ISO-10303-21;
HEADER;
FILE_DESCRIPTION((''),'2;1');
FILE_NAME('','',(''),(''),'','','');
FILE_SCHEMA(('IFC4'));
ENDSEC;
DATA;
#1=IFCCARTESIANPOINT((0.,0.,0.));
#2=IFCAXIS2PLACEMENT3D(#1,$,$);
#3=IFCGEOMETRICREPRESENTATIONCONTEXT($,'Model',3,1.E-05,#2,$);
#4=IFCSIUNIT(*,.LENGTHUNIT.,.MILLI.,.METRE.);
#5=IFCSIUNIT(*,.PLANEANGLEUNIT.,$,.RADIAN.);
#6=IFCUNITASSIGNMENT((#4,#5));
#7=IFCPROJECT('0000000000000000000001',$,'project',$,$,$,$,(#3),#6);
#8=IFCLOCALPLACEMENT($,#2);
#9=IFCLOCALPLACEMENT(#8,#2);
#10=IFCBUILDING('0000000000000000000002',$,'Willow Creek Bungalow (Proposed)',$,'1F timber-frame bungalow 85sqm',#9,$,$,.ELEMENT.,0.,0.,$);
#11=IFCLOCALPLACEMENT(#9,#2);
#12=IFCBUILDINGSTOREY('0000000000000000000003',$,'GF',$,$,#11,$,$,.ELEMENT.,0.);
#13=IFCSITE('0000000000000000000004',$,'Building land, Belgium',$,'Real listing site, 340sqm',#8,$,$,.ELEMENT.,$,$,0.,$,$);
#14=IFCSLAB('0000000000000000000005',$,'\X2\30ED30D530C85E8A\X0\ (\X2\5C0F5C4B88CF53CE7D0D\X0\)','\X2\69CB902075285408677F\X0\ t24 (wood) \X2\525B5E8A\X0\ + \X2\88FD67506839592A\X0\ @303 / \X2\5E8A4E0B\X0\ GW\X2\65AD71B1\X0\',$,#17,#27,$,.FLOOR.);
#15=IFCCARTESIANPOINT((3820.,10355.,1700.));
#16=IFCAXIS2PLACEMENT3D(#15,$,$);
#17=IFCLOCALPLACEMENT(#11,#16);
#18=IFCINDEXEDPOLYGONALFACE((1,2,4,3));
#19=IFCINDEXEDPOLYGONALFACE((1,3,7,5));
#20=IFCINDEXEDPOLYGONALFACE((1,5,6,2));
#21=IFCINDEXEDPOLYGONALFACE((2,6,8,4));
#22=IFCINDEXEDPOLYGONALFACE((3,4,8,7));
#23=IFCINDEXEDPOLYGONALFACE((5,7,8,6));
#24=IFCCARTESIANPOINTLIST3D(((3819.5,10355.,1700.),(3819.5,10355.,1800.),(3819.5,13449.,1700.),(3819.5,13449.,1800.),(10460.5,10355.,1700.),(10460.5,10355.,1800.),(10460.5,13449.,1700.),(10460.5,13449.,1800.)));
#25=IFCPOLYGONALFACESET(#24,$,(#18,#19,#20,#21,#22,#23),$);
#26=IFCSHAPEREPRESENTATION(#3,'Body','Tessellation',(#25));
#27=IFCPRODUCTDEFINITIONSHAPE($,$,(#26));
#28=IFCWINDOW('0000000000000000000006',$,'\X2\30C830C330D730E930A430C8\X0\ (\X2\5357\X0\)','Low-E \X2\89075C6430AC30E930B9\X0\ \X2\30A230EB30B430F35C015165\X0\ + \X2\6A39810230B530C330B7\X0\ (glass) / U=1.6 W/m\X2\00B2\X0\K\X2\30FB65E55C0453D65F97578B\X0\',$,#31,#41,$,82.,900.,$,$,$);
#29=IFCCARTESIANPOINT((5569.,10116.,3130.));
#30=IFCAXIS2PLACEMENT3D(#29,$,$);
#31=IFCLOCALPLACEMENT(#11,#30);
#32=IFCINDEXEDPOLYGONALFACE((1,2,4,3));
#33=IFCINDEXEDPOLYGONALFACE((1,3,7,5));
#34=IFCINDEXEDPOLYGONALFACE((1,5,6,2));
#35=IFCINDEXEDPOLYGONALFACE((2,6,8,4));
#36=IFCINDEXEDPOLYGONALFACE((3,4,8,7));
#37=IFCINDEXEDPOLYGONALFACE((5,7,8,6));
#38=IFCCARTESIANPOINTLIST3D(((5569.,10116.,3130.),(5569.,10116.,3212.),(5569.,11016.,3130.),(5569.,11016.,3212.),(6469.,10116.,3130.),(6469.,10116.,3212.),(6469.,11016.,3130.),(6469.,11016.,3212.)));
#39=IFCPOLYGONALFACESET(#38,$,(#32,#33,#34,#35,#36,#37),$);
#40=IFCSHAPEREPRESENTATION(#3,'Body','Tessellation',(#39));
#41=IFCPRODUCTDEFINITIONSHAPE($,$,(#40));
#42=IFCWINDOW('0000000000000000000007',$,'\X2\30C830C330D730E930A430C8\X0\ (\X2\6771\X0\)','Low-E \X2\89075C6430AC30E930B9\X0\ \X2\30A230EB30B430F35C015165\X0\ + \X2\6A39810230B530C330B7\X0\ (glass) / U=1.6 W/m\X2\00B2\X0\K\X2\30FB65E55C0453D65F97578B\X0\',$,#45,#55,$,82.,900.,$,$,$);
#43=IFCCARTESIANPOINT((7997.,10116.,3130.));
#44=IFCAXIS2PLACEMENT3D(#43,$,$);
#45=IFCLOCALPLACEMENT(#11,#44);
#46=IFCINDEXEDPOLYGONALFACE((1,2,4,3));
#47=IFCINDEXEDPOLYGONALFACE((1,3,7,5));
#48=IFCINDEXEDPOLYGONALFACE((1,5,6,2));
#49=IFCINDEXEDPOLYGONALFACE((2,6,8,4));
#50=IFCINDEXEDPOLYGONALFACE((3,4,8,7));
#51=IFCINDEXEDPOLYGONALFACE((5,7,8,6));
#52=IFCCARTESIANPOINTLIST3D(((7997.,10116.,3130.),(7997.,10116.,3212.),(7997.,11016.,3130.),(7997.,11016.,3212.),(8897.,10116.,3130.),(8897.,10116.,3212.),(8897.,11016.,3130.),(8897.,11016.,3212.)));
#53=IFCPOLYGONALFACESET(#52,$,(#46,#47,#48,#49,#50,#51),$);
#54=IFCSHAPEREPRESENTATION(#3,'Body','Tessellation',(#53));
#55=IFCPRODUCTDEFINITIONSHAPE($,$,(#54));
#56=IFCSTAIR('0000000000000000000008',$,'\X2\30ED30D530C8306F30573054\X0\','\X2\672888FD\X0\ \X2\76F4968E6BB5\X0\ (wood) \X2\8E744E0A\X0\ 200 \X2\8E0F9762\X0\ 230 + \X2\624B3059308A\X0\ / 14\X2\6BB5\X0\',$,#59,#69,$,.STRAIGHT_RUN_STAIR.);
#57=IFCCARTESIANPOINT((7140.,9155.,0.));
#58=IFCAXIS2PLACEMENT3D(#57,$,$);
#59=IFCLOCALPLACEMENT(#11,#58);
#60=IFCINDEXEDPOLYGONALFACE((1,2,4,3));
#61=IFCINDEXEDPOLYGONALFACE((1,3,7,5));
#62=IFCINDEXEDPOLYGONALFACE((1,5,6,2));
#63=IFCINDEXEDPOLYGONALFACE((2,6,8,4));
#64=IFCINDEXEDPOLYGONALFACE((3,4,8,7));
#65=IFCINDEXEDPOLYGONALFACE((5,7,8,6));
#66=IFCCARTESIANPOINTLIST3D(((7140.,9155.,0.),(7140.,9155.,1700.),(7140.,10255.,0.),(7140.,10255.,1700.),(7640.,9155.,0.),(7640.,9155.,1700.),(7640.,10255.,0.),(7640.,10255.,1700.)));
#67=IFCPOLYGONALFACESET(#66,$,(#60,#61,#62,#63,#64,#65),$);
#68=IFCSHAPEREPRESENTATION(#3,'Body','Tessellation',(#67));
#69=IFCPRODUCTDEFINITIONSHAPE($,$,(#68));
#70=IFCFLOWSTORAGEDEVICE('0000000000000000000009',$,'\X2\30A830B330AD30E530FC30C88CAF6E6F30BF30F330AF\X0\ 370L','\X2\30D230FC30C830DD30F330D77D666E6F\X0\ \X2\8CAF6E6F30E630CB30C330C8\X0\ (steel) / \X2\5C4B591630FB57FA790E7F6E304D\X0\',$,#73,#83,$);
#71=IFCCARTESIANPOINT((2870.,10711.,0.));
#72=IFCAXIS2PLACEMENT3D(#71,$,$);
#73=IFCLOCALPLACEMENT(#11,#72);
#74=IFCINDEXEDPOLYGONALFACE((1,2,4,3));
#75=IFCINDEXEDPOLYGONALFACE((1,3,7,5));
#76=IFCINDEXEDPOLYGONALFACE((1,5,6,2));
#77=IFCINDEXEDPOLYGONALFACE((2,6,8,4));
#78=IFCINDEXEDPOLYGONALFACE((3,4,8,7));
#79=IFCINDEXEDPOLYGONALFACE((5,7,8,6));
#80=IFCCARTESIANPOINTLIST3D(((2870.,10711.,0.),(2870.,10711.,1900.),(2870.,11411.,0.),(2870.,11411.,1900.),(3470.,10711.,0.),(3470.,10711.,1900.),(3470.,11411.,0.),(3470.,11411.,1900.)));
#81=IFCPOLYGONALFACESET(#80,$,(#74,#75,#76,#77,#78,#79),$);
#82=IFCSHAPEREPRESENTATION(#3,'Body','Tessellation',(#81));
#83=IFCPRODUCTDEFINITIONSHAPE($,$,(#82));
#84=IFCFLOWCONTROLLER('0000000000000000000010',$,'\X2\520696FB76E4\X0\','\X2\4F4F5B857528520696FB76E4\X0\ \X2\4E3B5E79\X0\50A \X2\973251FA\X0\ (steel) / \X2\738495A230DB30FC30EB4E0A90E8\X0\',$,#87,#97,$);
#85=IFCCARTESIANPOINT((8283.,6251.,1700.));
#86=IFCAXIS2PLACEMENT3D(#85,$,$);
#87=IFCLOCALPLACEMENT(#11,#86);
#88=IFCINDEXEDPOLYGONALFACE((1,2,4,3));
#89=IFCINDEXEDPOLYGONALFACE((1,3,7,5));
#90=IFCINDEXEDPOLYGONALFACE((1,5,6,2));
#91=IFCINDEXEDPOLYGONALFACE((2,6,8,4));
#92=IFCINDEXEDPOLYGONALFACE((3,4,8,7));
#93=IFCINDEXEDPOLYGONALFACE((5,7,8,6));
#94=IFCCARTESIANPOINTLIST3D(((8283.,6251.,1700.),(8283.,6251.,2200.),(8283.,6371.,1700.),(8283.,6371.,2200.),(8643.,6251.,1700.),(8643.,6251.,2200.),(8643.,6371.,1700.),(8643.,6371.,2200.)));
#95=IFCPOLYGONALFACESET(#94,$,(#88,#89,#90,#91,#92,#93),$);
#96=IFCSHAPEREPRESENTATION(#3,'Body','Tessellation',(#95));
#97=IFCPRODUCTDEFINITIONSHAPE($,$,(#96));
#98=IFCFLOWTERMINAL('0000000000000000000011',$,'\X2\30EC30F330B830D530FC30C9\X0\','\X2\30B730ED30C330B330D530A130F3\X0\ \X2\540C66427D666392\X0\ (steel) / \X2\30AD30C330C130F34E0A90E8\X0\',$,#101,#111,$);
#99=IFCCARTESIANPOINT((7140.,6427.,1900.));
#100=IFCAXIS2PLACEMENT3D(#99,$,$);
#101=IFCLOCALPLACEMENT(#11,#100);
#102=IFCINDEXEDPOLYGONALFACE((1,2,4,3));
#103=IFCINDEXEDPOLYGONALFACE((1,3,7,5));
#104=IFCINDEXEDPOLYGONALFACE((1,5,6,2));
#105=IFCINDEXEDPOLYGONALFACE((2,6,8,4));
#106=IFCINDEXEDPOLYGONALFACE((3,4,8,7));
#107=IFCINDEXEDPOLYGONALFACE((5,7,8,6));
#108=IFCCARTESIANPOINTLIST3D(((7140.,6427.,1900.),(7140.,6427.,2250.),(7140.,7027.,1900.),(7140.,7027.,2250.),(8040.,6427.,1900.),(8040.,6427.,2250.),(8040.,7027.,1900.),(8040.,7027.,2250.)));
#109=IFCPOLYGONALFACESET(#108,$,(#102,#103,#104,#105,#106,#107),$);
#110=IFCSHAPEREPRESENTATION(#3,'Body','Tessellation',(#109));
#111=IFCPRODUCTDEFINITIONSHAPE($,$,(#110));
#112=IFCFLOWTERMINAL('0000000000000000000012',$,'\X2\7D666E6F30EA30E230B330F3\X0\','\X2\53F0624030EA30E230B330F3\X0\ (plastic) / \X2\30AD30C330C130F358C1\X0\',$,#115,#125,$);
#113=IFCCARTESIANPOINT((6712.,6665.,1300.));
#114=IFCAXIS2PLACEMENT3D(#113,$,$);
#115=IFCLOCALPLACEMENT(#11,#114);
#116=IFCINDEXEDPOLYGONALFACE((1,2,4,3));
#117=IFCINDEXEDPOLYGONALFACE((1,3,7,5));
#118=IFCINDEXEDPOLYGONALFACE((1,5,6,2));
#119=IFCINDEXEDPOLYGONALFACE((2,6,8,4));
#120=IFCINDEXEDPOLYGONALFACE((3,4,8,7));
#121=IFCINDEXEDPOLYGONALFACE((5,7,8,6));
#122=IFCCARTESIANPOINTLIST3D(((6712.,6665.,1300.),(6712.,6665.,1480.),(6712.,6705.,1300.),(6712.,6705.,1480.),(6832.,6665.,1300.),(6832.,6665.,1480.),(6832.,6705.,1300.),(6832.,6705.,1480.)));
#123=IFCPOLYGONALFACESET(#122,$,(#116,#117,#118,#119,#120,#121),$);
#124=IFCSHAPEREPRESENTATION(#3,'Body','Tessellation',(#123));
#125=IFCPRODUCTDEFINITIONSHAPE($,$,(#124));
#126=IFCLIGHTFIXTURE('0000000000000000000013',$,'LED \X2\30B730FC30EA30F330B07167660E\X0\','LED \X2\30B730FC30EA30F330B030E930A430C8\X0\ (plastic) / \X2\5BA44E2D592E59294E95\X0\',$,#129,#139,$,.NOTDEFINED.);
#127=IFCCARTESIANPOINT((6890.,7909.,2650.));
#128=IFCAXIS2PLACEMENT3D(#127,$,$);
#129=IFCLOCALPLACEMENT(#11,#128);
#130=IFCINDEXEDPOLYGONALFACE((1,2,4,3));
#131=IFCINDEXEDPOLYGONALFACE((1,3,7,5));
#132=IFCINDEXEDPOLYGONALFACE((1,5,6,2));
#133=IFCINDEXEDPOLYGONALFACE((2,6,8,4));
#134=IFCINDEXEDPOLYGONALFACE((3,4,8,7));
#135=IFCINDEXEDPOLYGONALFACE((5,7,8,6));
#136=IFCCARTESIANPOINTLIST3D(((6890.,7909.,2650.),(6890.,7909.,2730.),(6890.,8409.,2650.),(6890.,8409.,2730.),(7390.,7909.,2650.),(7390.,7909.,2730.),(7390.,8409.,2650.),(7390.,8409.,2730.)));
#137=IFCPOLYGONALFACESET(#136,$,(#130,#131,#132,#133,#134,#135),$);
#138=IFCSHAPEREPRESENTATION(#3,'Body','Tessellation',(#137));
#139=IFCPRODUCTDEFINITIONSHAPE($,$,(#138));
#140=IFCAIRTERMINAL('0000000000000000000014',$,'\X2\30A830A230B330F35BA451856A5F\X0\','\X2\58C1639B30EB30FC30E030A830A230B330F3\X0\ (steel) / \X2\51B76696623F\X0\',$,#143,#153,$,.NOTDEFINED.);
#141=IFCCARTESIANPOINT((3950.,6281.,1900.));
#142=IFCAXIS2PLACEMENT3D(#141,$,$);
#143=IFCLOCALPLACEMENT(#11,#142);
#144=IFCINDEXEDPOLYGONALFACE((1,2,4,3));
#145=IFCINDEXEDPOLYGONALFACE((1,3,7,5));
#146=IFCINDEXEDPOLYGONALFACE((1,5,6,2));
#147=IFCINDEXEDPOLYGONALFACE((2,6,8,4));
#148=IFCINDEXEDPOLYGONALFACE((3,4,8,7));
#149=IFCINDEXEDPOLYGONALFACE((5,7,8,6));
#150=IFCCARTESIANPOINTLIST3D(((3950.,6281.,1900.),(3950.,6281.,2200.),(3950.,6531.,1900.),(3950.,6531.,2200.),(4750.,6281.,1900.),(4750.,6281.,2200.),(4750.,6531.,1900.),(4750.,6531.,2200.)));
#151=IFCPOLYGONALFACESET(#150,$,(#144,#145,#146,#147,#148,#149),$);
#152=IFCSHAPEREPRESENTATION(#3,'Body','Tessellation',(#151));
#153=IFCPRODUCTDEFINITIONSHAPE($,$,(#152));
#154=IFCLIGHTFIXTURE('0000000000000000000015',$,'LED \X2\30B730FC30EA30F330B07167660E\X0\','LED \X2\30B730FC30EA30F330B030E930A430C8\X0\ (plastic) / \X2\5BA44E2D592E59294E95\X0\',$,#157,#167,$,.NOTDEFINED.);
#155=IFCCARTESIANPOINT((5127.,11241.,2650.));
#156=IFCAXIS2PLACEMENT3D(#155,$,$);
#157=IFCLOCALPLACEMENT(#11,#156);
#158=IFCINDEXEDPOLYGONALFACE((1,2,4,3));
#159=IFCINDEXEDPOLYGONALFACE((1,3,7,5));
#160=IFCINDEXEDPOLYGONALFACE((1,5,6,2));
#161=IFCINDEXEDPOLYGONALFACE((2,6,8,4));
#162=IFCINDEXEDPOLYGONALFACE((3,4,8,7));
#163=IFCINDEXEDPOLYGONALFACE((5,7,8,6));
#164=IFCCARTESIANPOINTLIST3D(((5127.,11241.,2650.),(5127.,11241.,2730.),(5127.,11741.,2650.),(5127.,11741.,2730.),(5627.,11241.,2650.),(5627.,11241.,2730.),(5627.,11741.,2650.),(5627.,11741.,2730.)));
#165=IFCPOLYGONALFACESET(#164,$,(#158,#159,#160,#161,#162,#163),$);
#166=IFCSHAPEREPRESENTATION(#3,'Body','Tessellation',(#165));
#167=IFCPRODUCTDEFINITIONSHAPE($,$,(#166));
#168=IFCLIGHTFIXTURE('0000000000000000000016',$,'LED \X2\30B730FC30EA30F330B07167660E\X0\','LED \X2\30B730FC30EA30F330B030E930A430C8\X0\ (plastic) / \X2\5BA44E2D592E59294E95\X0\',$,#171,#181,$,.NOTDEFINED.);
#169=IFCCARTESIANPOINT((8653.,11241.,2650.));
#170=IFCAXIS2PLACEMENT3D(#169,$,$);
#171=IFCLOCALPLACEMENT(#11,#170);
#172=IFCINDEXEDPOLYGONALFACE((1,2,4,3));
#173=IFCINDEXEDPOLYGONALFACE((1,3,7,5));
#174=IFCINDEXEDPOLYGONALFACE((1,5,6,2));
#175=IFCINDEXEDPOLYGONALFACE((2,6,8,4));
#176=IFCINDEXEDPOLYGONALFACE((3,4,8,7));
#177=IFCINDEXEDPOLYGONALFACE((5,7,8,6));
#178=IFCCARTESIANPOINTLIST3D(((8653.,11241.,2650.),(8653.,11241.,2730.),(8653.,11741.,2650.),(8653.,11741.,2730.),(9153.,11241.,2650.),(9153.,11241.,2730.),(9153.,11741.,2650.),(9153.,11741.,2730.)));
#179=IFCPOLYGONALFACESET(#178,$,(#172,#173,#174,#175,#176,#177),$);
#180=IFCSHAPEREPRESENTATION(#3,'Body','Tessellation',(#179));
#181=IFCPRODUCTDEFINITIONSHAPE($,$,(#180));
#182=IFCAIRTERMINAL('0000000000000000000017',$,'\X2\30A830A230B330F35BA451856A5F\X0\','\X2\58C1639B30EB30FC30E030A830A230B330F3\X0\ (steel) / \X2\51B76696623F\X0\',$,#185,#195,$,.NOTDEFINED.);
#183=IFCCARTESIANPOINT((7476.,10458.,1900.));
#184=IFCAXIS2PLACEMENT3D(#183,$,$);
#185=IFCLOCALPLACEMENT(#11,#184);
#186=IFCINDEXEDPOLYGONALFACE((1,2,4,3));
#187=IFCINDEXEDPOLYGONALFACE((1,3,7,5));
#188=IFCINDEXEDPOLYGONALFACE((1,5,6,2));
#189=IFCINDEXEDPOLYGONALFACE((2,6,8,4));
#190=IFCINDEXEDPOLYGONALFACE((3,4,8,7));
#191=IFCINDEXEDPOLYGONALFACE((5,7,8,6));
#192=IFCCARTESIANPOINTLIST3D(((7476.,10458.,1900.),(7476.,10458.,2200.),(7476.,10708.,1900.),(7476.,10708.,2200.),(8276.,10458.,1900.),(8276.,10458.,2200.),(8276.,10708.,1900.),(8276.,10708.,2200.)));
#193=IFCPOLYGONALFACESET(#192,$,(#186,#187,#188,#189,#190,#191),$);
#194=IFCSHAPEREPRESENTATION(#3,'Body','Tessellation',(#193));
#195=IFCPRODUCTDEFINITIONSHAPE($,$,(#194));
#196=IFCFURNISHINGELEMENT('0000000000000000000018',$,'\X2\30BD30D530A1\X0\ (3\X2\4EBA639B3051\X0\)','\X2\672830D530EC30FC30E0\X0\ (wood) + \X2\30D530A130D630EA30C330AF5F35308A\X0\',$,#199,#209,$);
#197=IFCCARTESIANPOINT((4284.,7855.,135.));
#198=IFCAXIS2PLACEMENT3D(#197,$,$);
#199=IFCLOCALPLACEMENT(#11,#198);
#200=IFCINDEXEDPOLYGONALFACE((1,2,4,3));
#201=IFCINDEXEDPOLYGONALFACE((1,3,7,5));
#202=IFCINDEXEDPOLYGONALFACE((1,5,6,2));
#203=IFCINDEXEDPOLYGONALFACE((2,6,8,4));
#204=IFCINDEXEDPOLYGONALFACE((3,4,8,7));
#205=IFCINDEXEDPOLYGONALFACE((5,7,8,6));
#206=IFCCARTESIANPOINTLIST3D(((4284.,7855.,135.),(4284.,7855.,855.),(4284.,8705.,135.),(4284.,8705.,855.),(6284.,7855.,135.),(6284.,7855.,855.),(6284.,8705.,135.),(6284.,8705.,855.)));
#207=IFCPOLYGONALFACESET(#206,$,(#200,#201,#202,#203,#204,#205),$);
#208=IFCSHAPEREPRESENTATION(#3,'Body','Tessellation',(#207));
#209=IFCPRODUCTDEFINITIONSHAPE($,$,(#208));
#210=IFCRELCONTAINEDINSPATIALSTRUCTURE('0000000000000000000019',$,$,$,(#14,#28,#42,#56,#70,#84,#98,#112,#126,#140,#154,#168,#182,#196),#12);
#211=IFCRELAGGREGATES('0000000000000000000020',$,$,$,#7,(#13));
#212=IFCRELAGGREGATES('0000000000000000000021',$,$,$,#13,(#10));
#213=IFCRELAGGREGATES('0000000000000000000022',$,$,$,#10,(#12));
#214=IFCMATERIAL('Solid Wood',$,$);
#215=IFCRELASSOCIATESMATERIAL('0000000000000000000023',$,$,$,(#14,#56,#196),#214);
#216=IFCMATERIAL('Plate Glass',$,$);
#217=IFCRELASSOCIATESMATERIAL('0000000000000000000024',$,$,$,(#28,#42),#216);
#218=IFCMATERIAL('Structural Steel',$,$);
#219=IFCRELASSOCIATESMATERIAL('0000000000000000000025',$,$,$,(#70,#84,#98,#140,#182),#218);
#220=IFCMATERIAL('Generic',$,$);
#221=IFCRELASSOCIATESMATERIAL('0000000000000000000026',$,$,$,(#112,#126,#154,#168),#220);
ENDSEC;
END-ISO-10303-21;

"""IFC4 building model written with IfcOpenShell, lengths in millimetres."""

from ifc_helpers import new_model, si_unit, frame, frame_2d, origin, place, context, project, spatial, rectangle, extrude, material, element, save


model = new_model("IFC4")

# Units and contexts
model_context = context("Model", 3, precision=1e-05, world=origin())
ifc_project = project(units=[si_unit("LENGTHUNIT", "METRE", prefix="MILLI"), si_unit("PLANEANGLEUNIT", "RADIAN")], contexts=[model_context])

# Site, building, storey
site_placement = place(None, origin())
site = spatial("IfcSite", under=ifc_project, at=site_placement, Name="Building land, Belgium", ObjectType="Real listing site, 340sqm", CompositionType="ELEMENT", RefElevation=0.0)
building_placement = place(site_placement, origin())
building = spatial("IfcBuilding", under=site, at=building_placement, Name="Willow Creek Bungalow (Proposed)", ObjectType="1F timber-frame bungalow 85sqm", CompositionType="ELEMENT", ElevationOfRefHeight=0.0, ElevationOfTerrain=0.0)
storey_placement = place(building_placement, origin())
storey = spatial("IfcBuildingStorey", under=building, at=storey_placement, Name="GF", CompositionType="ELEMENT", Elevation=0.0)

# Shared definitions
ifc_material_1 = material(Name="Solid Wood")

# Slab
slab_placement = place(storey_placement, frame((3820.0, 10355.0, 1700.0)))
element("IfcSlab", 1, at=slab_placement, inside=storey, material=ifc_material_1, Name="ロフト床 (小屋裏収納)", Description="構造用合板 t24 (wood) 剛床 + 製材根太 @303 / 床下 GW断熱", PredefinedType="FLOOR", context=model_context, shape_type="SweptSolid", body=[
    extrude(rectangle(XDim=6641.0, YDim=3094.0, at=frame_2d((3320.0, 1547.0))), frame((3820.0, 10355.0, 1700.0)), (0.0, 0.0, 1.0), 100.0),
])

# Windows
ifc_material_2 = material(Name="Plate Glass")
window_1_placement = place(storey_placement, frame((5569.0, 10116.0, 3130.0)))
element("IfcWindow", 2, at=window_1_placement, inside=storey, material=ifc_material_2, Name="トップライト (南)", Description="Low-E 複層ガラス アルゴン封入 + 樹脂サッシ (glass) / U=1.6 W/m²K・日射取得型", OverallHeight=82.0, OverallWidth=900.0, context=model_context, shape_type="SweptSolid", body=[
    extrude(rectangle(XDim=900.0, YDim=900.0, at=frame_2d((450.0, 450.0))), frame((5569.0, 10116.0, 3130.0)), (0.0, 0.0, 1.0), 82.0),
])
window_2_placement = place(storey_placement, frame((7997.0, 10116.0, 3130.0)))
element("IfcWindow", 3, at=window_2_placement, inside=storey, material=ifc_material_2, Name="トップライト (東)", Description="Low-E 複層ガラス アルゴン封入 + 樹脂サッシ (glass) / U=1.6 W/m²K・日射取得型", OverallHeight=82.0, OverallWidth=900.0, context=model_context, shape_type="SweptSolid", body=[
    extrude(rectangle(XDim=900.0, YDim=900.0, at=frame_2d((450.0, 450.0))), frame((7997.0, 10116.0, 3130.0)), (0.0, 0.0, 1.0), 82.0),
])

# Stair
stair_placement = place(storey_placement, frame((7140.0, 9155.0, 0.0)))
element("IfcStair", 4, at=stair_placement, inside=storey, material=ifc_material_1, Name="ロフトはしご", Description="木製 直階段 (wood) 蹴上 200 踏面 230 + 手すり / 14段", PredefinedType="STRAIGHT_RUN_STAIR", context=model_context, shape_type="SweptSolid", body=[
    extrude(rectangle(XDim=500.0, YDim=1100.0, at=frame_2d((250.0, 550.0))), frame((7140.0, 9155.0, 0.0)), (0.0, 0.0, 1.0), 1700.0),
])

# Flow storage device
ifc_material_3 = material(Name="Structural Steel")
flow_storage_device_placement = place(storey_placement, frame((2870.0, 10711.0, 0.0)))
element("IfcFlowStorageDevice", 5, at=flow_storage_device_placement, inside=storey, material=ifc_material_3, Name="エコキュート貯湯タンク 370L", Description="ヒートポンプ給湯 貯湯ユニット (steel) / 屋外・基礎置き", context=model_context, shape_type="SweptSolid", body=[
    extrude(rectangle(XDim=600.0, YDim=700.0, at=frame_2d((300.0, 350.0))), frame((2870.0, 10711.0, 0.0)), (0.0, 0.0, 1.0), 1900.0),
])

# Flow controller
flow_controller_placement = place(storey_placement, frame((8283.0, 6251.0, 1700.0)))
element("IfcFlowController", 6, at=flow_controller_placement, inside=storey, material=ifc_material_3, Name="分電盤", Description="住宅用分電盤 主幹50A 露出 (steel) / 玄関ホール上部", context=model_context, shape_type="SweptSolid", body=[
    extrude(rectangle(XDim=360.0, YDim=120.0, at=frame_2d((180.0, 60.0))), frame((8283.0, 6251.0, 1700.0)), (0.0, 0.0, 1.0), 500.0),
])

# Flow terminals
flow_terminal_1_placement = place(storey_placement, frame((7140.0, 6427.0, 1900.0)))
element("IfcFlowTerminal", 7, at=flow_terminal_1_placement, inside=storey, material=ifc_material_3, Name="レンジフード", Description="シロッコファン 同時給排 (steel) / キッチン上部", context=model_context, shape_type="SweptSolid", body=[
    extrude(rectangle(XDim=900.0, YDim=600.0, at=frame_2d((450.0, 300.0))), frame((7140.0, 6427.0, 1900.0)), (0.0, 0.0, 1.0), 350.0),
])
ifc_material_4 = material(Name="Generic")
flow_terminal_2_placement = place(storey_placement, frame((6712.0, 6665.0, 1300.0)))
element("IfcFlowTerminal", 8, at=flow_terminal_2_placement, inside=storey, material=ifc_material_4, Name="給湯リモコン", Description="台所リモコン (plastic) / キッチン壁", context=model_context, shape_type="SweptSolid", body=[
    extrude(rectangle(XDim=120.0, YDim=40.0, at=frame_2d((60.0, 20.0))), frame((6712.0, 6665.0, 1300.0)), (0.0, 0.0, 1.0), 180.0),
])

# Light fixture
light_fixture_1_placement = place(storey_placement, frame((6890.0, 7909.0, 2650.0)))
element("IfcLightFixture", 9, at=light_fixture_1_placement, inside=storey, material=ifc_material_4, Name="LED シーリング照明", Description="LED シーリングライト (plastic) / 室中央天井", PredefinedType="NOTDEFINED", context=model_context, shape_type="SweptSolid", body=[
    extrude(rectangle(XDim=500.0, YDim=500.0, at=frame_2d((250.0, 250.0))), frame((6890.0, 7909.0, 2650.0)), (0.0, 0.0, 1.0), 80.0),
])

# Air terminal
air_terminal_1_placement = place(storey_placement, frame((3950.0, 6281.0, 1900.0)))
element("IfcAirTerminal", 10, at=air_terminal_1_placement, inside=storey, material=ifc_material_3, Name="エアコン室内機", Description="壁掛ルームエアコン (steel) / 冷暖房", PredefinedType="NOTDEFINED", context=model_context, shape_type="SweptSolid", body=[
    extrude(rectangle(XDim=800.0, YDim=250.0, at=frame_2d((400.0, 125.0))), frame((3950.0, 6281.0, 1900.0)), (0.0, 0.0, 1.0), 300.0),
])

# Light fixtures
light_fixture_2_placement = place(storey_placement, frame((5127.0, 11241.0, 2650.0)))
element("IfcLightFixture", 11, at=light_fixture_2_placement, inside=storey, material=ifc_material_4, Name="LED シーリング照明", Description="LED シーリングライト (plastic) / 室中央天井", PredefinedType="NOTDEFINED", context=model_context, shape_type="SweptSolid", body=[
    extrude(rectangle(XDim=500.0, YDim=500.0, at=frame_2d((250.0, 250.0))), frame((5127.0, 11241.0, 2650.0)), (0.0, 0.0, 1.0), 80.0),
])
light_fixture_3_placement = place(storey_placement, frame((8653.0, 11241.0, 2650.0)))
element("IfcLightFixture", 12, at=light_fixture_3_placement, inside=storey, material=ifc_material_4, Name="LED シーリング照明", Description="LED シーリングライト (plastic) / 室中央天井", PredefinedType="NOTDEFINED", context=model_context, shape_type="SweptSolid", body=[
    extrude(rectangle(XDim=500.0, YDim=500.0, at=frame_2d((250.0, 250.0))), frame((8653.0, 11241.0, 2650.0)), (0.0, 0.0, 1.0), 80.0),
])

# Air terminal
air_terminal_2_placement = place(storey_placement, frame((7476.0, 10458.0, 1900.0)))
element("IfcAirTerminal", 13, at=air_terminal_2_placement, inside=storey, material=ifc_material_3, Name="エアコン室内機", Description="壁掛ルームエアコン (steel) / 冷暖房", PredefinedType="NOTDEFINED", context=model_context, shape_type="SweptSolid", body=[
    extrude(rectangle(XDim=800.0, YDim=250.0, at=frame_2d((400.0, 125.0))), frame((7476.0, 10458.0, 1900.0)), (0.0, 0.0, 1.0), 300.0),
])

# Furnishing element
furnishing_1_placement = place(storey_placement, frame((4284.0, 7855.0, 135.0)))
element("IfcFurnishingElement", 14, at=furnishing_1_placement, inside=storey, material=ifc_material_1, Name="ソファ (3人掛け)", Description="木フレーム (wood) + ファブリック張り", context=model_context, shape_type="SweptSolid", body=[
    extrude(rectangle(XDim=2000.0, YDim=850.0, at=frame_2d((1000.0, 425.0))), frame((4284.0, 7855.0, 135.0)), (0.0, 0.0, 1.0), 720.0),
])

save(model, "model.ifc")
